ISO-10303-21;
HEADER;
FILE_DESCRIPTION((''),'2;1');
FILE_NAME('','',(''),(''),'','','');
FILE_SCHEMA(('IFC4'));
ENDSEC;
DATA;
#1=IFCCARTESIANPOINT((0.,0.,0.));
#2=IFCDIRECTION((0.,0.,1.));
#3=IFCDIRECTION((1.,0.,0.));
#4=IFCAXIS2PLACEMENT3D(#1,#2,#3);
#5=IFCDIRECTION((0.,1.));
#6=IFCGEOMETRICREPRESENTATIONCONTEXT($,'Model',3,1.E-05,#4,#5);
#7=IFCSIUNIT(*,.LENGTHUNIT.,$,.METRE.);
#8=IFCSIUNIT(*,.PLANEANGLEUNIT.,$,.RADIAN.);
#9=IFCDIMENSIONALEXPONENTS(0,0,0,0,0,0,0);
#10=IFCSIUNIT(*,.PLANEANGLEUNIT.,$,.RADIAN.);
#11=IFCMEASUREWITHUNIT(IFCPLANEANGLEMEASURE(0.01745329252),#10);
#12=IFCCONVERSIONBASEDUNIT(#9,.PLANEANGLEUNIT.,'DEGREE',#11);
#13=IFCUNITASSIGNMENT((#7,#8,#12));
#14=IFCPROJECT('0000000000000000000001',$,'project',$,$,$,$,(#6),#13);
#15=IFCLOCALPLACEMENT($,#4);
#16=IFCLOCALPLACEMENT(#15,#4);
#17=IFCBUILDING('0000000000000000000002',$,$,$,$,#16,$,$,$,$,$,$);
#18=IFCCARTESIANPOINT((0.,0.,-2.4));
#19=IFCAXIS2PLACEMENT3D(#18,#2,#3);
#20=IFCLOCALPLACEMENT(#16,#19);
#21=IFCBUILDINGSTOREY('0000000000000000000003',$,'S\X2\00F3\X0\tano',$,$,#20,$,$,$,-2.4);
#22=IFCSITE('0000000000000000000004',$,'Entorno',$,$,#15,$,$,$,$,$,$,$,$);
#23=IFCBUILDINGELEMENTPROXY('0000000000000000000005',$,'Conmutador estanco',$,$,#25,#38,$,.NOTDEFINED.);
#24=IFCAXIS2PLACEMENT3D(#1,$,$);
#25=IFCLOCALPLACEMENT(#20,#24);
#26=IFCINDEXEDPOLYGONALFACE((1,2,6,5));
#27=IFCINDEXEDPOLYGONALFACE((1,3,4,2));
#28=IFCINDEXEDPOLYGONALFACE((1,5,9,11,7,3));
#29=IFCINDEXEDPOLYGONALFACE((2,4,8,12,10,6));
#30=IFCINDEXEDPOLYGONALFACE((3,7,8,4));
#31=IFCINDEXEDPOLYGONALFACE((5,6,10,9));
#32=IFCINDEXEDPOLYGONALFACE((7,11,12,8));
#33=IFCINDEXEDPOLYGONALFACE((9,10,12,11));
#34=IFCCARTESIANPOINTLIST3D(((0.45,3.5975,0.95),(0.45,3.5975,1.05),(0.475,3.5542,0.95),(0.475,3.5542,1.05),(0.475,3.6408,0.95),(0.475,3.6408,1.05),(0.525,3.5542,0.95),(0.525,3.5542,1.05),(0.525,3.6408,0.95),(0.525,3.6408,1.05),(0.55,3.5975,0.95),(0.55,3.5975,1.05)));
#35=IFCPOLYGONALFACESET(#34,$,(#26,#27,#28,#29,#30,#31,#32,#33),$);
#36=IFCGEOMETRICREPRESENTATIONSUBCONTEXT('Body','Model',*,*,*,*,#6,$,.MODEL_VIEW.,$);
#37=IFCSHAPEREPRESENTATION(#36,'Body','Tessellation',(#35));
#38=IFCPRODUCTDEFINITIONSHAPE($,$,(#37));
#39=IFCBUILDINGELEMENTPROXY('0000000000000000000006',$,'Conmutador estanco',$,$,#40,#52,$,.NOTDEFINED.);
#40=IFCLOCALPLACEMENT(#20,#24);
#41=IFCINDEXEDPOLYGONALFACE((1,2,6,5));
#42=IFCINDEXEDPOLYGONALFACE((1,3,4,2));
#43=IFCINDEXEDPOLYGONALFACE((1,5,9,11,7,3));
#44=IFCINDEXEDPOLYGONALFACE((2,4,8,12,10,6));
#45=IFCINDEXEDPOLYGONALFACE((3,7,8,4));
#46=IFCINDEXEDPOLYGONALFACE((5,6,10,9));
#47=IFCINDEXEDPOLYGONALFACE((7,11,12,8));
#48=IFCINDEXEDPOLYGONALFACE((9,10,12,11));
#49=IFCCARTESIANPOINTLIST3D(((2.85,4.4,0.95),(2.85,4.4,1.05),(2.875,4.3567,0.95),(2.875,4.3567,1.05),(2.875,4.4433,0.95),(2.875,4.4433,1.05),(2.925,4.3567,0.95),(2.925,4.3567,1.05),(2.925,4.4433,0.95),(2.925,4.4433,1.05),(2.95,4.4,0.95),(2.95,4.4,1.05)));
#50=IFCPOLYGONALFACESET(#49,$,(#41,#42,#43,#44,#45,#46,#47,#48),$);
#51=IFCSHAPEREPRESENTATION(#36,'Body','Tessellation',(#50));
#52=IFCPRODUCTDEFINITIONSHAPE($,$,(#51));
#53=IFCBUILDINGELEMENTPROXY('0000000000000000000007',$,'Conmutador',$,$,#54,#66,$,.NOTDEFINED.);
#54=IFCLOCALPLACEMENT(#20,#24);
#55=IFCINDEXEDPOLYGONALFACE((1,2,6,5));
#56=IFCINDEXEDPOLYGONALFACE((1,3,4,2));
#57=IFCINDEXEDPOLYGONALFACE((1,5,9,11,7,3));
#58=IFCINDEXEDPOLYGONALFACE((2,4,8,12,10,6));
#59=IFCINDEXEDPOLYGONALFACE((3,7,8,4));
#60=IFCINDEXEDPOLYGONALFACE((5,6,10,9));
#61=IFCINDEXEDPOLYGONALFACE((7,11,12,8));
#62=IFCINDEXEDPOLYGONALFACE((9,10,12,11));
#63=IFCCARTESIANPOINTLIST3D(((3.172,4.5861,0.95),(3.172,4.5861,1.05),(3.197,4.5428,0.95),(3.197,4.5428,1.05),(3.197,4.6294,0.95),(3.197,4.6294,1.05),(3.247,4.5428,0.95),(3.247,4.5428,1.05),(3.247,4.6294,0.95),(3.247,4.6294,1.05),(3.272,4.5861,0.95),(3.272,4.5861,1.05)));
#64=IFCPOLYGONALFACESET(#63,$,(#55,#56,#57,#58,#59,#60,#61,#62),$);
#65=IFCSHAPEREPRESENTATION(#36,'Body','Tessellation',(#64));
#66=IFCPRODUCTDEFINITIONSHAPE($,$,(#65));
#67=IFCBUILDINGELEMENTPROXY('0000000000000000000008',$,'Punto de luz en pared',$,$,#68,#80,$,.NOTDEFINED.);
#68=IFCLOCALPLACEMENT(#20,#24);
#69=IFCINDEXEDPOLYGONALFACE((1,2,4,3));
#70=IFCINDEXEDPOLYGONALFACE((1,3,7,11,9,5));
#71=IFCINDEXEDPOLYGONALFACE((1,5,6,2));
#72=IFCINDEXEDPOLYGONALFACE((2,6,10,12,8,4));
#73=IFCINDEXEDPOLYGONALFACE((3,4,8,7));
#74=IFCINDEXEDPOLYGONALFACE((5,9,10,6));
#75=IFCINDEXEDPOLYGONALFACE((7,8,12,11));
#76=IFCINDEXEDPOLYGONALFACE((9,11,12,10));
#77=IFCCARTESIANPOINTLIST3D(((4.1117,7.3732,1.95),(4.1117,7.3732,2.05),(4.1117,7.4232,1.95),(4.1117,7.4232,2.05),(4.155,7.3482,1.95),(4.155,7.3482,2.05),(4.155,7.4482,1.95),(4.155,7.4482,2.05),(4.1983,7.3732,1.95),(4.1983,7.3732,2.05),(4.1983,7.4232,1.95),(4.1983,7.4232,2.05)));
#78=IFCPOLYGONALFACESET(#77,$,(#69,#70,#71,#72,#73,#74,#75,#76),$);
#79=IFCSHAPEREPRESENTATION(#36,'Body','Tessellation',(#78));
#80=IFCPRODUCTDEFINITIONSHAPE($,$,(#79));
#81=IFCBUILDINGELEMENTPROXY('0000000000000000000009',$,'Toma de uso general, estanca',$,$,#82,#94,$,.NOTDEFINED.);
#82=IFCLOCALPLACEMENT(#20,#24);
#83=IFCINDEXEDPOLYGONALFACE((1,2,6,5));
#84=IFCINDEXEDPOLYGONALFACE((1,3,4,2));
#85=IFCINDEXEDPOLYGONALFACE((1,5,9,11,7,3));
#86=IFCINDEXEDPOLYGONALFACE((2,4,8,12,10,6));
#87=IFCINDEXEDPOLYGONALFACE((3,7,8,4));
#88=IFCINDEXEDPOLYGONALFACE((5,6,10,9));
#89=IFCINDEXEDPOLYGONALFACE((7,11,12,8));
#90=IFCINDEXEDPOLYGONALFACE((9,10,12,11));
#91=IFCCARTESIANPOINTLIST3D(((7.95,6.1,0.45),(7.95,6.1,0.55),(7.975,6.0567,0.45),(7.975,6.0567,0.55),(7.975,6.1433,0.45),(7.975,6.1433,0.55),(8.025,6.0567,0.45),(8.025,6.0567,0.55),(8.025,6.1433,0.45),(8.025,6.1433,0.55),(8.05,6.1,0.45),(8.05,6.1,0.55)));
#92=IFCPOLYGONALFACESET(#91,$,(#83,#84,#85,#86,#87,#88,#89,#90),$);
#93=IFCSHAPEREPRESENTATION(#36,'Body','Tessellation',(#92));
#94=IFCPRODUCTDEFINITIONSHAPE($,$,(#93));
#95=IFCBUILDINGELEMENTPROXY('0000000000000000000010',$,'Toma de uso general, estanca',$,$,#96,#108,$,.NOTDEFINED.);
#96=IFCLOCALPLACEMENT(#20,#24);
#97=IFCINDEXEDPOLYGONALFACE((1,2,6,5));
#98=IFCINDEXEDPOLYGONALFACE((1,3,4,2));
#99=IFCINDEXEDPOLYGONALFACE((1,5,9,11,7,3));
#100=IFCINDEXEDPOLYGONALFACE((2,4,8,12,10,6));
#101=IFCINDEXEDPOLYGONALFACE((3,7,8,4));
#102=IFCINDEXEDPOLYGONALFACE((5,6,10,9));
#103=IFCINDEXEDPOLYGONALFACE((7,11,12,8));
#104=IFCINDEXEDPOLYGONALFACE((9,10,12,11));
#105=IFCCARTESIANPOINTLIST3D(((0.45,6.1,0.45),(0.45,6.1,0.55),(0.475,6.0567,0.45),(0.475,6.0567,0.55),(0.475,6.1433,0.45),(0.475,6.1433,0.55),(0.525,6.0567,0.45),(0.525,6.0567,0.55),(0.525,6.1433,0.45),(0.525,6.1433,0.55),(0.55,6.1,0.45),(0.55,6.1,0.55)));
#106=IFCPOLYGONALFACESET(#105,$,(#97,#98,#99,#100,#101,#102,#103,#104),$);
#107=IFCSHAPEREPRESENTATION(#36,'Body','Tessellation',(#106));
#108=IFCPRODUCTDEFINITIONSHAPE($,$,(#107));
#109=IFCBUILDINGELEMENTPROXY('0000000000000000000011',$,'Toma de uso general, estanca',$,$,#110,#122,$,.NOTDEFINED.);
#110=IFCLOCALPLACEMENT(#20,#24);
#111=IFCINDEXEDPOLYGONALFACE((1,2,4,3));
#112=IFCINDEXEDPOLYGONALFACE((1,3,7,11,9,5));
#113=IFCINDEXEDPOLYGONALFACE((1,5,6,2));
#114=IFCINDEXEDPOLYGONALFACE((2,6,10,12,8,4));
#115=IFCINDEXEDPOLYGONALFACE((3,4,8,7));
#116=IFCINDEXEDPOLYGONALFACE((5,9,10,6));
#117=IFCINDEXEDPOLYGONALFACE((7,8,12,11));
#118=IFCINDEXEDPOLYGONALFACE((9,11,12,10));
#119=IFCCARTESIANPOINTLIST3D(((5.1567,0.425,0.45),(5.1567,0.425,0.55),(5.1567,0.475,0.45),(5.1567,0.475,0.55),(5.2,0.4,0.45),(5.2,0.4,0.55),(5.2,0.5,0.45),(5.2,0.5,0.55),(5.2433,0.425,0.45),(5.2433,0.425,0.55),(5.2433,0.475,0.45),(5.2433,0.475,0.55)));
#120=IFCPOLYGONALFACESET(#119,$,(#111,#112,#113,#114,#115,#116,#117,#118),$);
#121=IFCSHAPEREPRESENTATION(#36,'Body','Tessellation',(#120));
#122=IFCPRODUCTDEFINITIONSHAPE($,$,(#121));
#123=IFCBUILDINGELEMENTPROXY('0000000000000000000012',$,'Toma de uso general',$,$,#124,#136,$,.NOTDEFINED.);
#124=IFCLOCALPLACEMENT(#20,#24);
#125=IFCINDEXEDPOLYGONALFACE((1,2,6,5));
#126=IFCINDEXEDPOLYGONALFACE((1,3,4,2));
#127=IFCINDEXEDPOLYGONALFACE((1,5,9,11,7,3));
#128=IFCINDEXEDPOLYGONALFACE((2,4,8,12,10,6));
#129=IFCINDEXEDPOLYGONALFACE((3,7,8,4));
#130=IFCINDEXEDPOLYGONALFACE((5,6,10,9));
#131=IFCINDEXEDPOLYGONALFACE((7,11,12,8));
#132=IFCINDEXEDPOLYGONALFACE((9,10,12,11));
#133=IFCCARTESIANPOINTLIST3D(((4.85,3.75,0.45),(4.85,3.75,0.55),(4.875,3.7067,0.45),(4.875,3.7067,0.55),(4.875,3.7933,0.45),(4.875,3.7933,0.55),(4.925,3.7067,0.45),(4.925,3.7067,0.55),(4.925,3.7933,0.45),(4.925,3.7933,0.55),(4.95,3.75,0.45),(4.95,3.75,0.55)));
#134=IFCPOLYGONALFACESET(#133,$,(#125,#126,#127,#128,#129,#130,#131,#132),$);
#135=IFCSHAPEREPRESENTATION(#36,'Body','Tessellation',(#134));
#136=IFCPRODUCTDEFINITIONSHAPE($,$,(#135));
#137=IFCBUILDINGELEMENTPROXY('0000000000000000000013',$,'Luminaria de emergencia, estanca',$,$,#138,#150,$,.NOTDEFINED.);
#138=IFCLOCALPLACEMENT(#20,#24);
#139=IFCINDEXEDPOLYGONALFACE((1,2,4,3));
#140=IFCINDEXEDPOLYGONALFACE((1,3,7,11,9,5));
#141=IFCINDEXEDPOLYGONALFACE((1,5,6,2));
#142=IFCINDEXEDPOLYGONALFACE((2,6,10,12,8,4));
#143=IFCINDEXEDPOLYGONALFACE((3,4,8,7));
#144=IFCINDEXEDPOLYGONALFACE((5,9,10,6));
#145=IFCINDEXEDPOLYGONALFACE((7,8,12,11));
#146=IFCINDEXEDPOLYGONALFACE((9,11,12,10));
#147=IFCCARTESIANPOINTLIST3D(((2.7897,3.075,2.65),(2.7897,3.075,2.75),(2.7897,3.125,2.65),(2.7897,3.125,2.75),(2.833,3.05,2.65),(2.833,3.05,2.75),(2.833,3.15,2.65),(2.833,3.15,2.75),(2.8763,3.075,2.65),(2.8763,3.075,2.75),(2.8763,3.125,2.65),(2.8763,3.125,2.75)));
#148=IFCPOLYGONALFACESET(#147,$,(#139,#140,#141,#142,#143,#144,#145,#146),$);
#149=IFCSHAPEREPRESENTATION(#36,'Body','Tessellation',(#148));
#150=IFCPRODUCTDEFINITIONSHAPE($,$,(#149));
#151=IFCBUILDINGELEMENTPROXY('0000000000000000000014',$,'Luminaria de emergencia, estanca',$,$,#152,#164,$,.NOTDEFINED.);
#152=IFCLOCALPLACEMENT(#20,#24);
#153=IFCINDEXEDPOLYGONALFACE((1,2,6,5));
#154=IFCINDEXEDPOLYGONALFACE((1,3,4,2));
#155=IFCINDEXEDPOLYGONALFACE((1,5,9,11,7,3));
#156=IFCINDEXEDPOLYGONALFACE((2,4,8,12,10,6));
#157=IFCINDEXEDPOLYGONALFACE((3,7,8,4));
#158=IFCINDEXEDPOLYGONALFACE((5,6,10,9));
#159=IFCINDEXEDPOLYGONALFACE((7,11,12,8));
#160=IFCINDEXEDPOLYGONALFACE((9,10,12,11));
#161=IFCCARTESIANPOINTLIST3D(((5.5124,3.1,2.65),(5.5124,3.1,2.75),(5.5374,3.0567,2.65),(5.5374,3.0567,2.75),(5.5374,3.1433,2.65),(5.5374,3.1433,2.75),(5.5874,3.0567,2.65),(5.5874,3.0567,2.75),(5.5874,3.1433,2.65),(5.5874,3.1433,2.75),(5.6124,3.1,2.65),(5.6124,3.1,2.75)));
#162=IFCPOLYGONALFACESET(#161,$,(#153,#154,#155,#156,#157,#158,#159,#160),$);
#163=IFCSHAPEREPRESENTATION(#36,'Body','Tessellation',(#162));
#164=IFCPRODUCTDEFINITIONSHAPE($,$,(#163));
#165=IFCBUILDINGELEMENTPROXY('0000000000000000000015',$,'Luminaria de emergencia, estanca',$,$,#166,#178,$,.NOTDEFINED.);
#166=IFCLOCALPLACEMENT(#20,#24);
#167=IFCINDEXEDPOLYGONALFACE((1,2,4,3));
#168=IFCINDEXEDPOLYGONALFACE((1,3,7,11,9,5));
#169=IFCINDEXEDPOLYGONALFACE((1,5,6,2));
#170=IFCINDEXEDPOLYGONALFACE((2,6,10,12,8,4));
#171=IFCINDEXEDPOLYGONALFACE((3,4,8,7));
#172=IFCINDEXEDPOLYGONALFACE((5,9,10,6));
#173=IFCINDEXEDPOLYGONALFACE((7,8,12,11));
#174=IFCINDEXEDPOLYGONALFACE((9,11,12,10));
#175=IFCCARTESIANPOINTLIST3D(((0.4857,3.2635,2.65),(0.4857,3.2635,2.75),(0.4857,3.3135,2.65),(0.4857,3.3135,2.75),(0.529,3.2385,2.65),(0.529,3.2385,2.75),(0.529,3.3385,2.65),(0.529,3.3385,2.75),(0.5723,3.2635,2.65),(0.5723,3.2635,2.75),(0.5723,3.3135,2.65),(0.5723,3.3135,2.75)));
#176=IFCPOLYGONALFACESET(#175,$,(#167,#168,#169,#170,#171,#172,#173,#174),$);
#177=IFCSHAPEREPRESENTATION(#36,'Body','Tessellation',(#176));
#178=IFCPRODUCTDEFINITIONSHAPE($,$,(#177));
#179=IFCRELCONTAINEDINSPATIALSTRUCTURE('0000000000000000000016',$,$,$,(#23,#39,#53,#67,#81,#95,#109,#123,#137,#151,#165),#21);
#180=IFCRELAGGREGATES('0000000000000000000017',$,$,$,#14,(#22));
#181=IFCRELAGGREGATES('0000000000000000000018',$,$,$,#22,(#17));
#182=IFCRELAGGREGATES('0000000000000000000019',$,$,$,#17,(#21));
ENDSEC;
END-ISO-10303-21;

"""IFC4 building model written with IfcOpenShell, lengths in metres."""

from ifc_helpers import new_model, entity, si_unit, converted_unit, direction, frame, origin_with_axes, place, context, subcontext, project, spatial, polyline, outline, extrude, source, transform, mapped, element, save


model = new_model("IFC4")

# Units and contexts
model_context = context("Model", 3, precision=1e-05, world=origin_with_axes(), true_north=direction((0.0, 1.0)))
body_context = subcontext(model_context, "Body", "Model", "MODEL_VIEW")
ifc_project = project(units=[si_unit("LENGTHUNIT", "METRE"), si_unit("PLANEANGLEUNIT", "RADIAN"), converted_unit("PLANEANGLEUNIT", "DEGREE", entity("IfcPlaneAngleMeasure", 0.01745329252), si_unit("PLANEANGLEUNIT", "RADIAN"), dimensions=[0, 0, 0, 0, 0, 0, 0])], contexts=[model_context])

# Site, building, storey
site_placement = place(None, origin_with_axes())
site = spatial("IfcSite", under=ifc_project, at=site_placement, Name="Entorno")
building_placement = place(site_placement, origin_with_axes())
building = spatial("IfcBuilding", under=site, at=building_placement)
storey_placement = place(building_placement, frame((0.0, 0.0, -2.4), z_axis=(0.0, 0.0, 1.0), x_axis=(1.0, 0.0, 0.0)))
storey = spatial("IfcBuildingStorey", under=building, at=storey_placement, Name="Sótano", Elevation=-2.4)

# Building element proxies
shared_shape_1 = source(origin_with_axes(), body_context, "Body", "SolidModel", [
    extrude(outline(polyline([(0.05, 0.0), (0.025, 0.0433), (-0.025, 0.0433), (-0.05, 0.0), (-0.025, -0.0433), (0.025, -0.0433), (0.05, 0.0)])), frame((0.0, 0.0, -0.05), z_axis=(0.0, 0.0, 1.0), x_axis=(1.0, 0.0, 0.0)), (0.0, 0.0, 1.0), 0.1),
])
proxy_1_placement = place(storey_placement, frame((0.0, 0.0, 2.4), z_axis=(0.0, 0.0, 1.0), x_axis=(1.0, 0.0, 0.0)))
element("IfcBuildingElementProxy", 1, at=proxy_1_placement, inside=storey, Name="Conmutador estanco", PredefinedType="NOTDEFINED", context=body_context, shape_type="Brep", body=[
    mapped(shared_shape_1, transform((0.5, 3.5975, -1.4), x_axis=(1.0, 0.0, 0.0), y_axis=(0.0, 1.0, 0.0), z_axis=(0.0, 0.0, 1.0))),
])
proxy_2_placement = place(storey_placement, frame((0.0, 0.0, 2.4), z_axis=(0.0, 0.0, 1.0), x_axis=(1.0, 0.0, 0.0)))
element("IfcBuildingElementProxy", 2, at=proxy_2_placement, inside=storey, Name="Conmutador estanco", PredefinedType="NOTDEFINED", context=body_context, shape_type="Brep", body=[
    mapped(shared_shape_1, transform((2.9, 4.4, -1.4), x_axis=(1.0, 0.0, 0.0), y_axis=(0.0, 1.0, 0.0), z_axis=(0.0, 0.0, 1.0))),
])
shared_shape_2 = source(origin_with_axes(), body_context, "Body", "SolidModel", [
    extrude(outline(polyline([(0.05, 0.0), (0.025, 0.0433), (-0.025, 0.0433), (-0.05, 0.0), (-0.025, -0.0433), (0.025, -0.0433), (0.05, 0.0)])), frame((0.0, 0.0, -0.05), z_axis=(0.0, 0.0, 1.0), x_axis=(1.0, 0.0, 0.0)), (0.0, 0.0, 1.0), 0.1),
])
proxy_3_placement = place(storey_placement, frame((0.0, 0.0, 2.4), z_axis=(0.0, 0.0, 1.0), x_axis=(1.0, 0.0, 0.0)))
element("IfcBuildingElementProxy", 3, at=proxy_3_placement, inside=storey, Name="Conmutador", PredefinedType="NOTDEFINED", context=body_context, shape_type="Brep", body=[
    mapped(shared_shape_2, transform((3.222, 4.5861, -1.4), x_axis=(1.0, 0.0, 0.0), y_axis=(0.0, 1.0, 0.0), z_axis=(0.0, 0.0, 1.0))),
])
shared_shape_3 = source(origin_with_axes(), body_context, "Body", "SolidModel", [
    extrude(outline(polyline([(0.05, 0.0), (0.025, 0.0433), (-0.025, 0.0433), (-0.05, 0.0), (-0.025, -0.0433), (0.025, -0.0433), (0.05, 0.0)])), frame((0.0, 0.0, -0.05), z_axis=(0.0, 0.0, 1.0), x_axis=(1.0, 0.0, 0.0)), (0.0, 0.0, 1.0), 0.1),
])
proxy_4_placement = place(storey_placement, frame((0.0, 0.0, 2.4), z_axis=(0.0, 0.0, 1.0), x_axis=(1.0, 0.0, 0.0)))
element("IfcBuildingElementProxy", 4, at=proxy_4_placement, inside=storey, Name="Punto de luz en pared", PredefinedType="NOTDEFINED", context=body_context, shape_type="Brep", body=[
    mapped(shared_shape_3, transform((4.155, 7.3982, -0.4), x_axis=(0.0, -1.0, 0.0), y_axis=(1.0, 0.0, 0.0), z_axis=(0.0, 0.0, 1.0))),
])
shared_shape_4 = source(origin_with_axes(), body_context, "Body", "SolidModel", [
    extrude(outline(polyline([(0.05, 0.0), (0.025, 0.0433), (-0.025, 0.0433), (-0.05, 0.0), (-0.025, -0.0433), (0.025, -0.0433), (0.05, 0.0)])), frame((0.0, 0.0, -0.05), z_axis=(0.0, 0.0, 1.0), x_axis=(1.0, 0.0, 0.0)), (0.0, 0.0, 1.0), 0.1),
])
proxy_5_placement = place(storey_placement, frame((0.0, 0.0, 2.4), z_axis=(0.0, 0.0, 1.0), x_axis=(1.0, 0.0, 0.0)))
element("IfcBuildingElementProxy", 5, at=proxy_5_placement, inside=storey, Name="Toma de uso general, estanca", PredefinedType="NOTDEFINED", context=body_context, shape_type="Brep", body=[
    mapped(shared_shape_4, transform((8.0, 6.1, -1.9), x_axis=(1.0, 0.0, 0.0), y_axis=(0.0, 1.0, 0.0), z_axis=(0.0, 0.0, 1.0))),
])
proxy_6_placement = place(storey_placement, frame((0.0, 0.0, 2.4), z_axis=(0.0, 0.0, 1.0), x_axis=(1.0, 0.0, 0.0)))
element("IfcBuildingElementProxy", 6, at=proxy_6_placement, inside=storey, Name="Toma de uso general, estanca", PredefinedType="NOTDEFINED", context=body_context, shape_type="Brep", body=[
    mapped(shared_shape_4, transform((0.5, 6.1, -1.9), x_axis=(-1.0, 0.0, 0.0), y_axis=(0.0, -1.0, 0.0), z_axis=(0.0, 0.0, 1.0))),
])
proxy_7_placement = place(storey_placement, frame((0.0, 0.0, 2.4), z_axis=(0.0, 0.0, 1.0), x_axis=(1.0, 0.0, 0.0)))
element("IfcBuildingElementProxy", 7, at=proxy_7_placement, inside=storey, Name="Toma de uso general, estanca", PredefinedType="NOTDEFINED", context=body_context, shape_type="Brep", body=[
    mapped(shared_shape_4, transform((5.2, 0.45, -1.9), x_axis=(0.0, -1.0, 0.0), y_axis=(1.0, 0.0, 0.0), z_axis=(0.0, 0.0, 1.0))),
])
shared_shape_5 = source(origin_with_axes(), body_context, "Body", "SolidModel", [
    extrude(outline(polyline([(0.05, 0.0), (0.025, 0.0433), (-0.025, 0.0433), (-0.05, 0.0), (-0.025, -0.0433), (0.025, -0.0433), (0.05, 0.0)])), frame((0.0, 0.0, -0.05), z_axis=(0.0, 0.0, 1.0), x_axis=(1.0, 0.0, 0.0)), (0.0, 0.0, 1.0), 0.1),
])
proxy_8_placement = place(storey_placement, frame((0.0, 0.0, 2.4), z_axis=(0.0, 0.0, 1.0), x_axis=(1.0, 0.0, 0.0)))
element("IfcBuildingElementProxy", 8, at=proxy_8_placement, inside=storey, Name="Toma de uso general", PredefinedType="NOTDEFINED", context=body_context, shape_type="Brep", body=[
    mapped(shared_shape_5, transform((4.9, 3.75, -1.9), x_axis=(1.0, 0.0, 0.0), y_axis=(0.0, 1.0, 0.0), z_axis=(0.0, 0.0, 1.0))),
])
shared_shape_6 = source(origin_with_axes(), body_context, "Body", "SolidModel", [
    extrude(outline(polyline([(0.05, 0.0), (0.025, 0.0433), (-0.025, 0.0433), (-0.05, 0.0), (-0.025, -0.0433), (0.025, -0.0433), (0.05, 0.0)])), frame((0.0, 0.0, -0.05), z_axis=(0.0, 0.0, 1.0), x_axis=(1.0, 0.0, 0.0)), (0.0, 0.0, 1.0), 0.1),
])
proxy_9_placement = place(storey_placement, frame((0.0, 0.0, 2.4), z_axis=(0.0, 0.0, 1.0), x_axis=(1.0, 0.0, 0.0)))
element("IfcBuildingElementProxy", 9, at=proxy_9_placement, inside=storey, Name="Luminaria de emergencia, estanca", PredefinedType="NOTDEFINED", context=body_context, shape_type="Brep", body=[
    mapped(shared_shape_6, transform((2.833, 3.1, 0.3), x_axis=(0.0, 1.0, 0.0), y_axis=(-1.0, 0.0, 0.0), z_axis=(0.0, 0.0, 1.0))),
])
proxy_10_placement = place(storey_placement, frame((0.0, 0.0, 2.4), z_axis=(0.0, 0.0, 1.0), x_axis=(1.0, 0.0, 0.0)))
element("IfcBuildingElementProxy", 10, at=proxy_10_placement, inside=storey, Name="Luminaria de emergencia, estanca", PredefinedType="NOTDEFINED", context=body_context, shape_type="Brep", body=[
    mapped(shared_shape_6, transform((5.5624, 3.1, 0.3), x_axis=(-1.0, 0.0, 0.0), y_axis=(0.0, -1.0, 0.0), z_axis=(0.0, 0.0, 1.0))),
])
proxy_11_placement = place(storey_placement, frame((0.0, 0.0, 2.4), z_axis=(0.0, 0.0, 1.0), x_axis=(1.0, 0.0, 0.0)))
element("IfcBuildingElementProxy", 11, at=proxy_11_placement, inside=storey, Name="Luminaria de emergencia, estanca", PredefinedType="NOTDEFINED", context=body_context, shape_type="Brep", body=[
    mapped(shared_shape_6, transform((0.529, 3.2885, 0.3), x_axis=(0.0, 1.0, 0.0), y_axis=(-1.0, 0.0, 0.0), z_axis=(0.0, 0.0, 1.0))),
])

save(model, "model.ifc")
